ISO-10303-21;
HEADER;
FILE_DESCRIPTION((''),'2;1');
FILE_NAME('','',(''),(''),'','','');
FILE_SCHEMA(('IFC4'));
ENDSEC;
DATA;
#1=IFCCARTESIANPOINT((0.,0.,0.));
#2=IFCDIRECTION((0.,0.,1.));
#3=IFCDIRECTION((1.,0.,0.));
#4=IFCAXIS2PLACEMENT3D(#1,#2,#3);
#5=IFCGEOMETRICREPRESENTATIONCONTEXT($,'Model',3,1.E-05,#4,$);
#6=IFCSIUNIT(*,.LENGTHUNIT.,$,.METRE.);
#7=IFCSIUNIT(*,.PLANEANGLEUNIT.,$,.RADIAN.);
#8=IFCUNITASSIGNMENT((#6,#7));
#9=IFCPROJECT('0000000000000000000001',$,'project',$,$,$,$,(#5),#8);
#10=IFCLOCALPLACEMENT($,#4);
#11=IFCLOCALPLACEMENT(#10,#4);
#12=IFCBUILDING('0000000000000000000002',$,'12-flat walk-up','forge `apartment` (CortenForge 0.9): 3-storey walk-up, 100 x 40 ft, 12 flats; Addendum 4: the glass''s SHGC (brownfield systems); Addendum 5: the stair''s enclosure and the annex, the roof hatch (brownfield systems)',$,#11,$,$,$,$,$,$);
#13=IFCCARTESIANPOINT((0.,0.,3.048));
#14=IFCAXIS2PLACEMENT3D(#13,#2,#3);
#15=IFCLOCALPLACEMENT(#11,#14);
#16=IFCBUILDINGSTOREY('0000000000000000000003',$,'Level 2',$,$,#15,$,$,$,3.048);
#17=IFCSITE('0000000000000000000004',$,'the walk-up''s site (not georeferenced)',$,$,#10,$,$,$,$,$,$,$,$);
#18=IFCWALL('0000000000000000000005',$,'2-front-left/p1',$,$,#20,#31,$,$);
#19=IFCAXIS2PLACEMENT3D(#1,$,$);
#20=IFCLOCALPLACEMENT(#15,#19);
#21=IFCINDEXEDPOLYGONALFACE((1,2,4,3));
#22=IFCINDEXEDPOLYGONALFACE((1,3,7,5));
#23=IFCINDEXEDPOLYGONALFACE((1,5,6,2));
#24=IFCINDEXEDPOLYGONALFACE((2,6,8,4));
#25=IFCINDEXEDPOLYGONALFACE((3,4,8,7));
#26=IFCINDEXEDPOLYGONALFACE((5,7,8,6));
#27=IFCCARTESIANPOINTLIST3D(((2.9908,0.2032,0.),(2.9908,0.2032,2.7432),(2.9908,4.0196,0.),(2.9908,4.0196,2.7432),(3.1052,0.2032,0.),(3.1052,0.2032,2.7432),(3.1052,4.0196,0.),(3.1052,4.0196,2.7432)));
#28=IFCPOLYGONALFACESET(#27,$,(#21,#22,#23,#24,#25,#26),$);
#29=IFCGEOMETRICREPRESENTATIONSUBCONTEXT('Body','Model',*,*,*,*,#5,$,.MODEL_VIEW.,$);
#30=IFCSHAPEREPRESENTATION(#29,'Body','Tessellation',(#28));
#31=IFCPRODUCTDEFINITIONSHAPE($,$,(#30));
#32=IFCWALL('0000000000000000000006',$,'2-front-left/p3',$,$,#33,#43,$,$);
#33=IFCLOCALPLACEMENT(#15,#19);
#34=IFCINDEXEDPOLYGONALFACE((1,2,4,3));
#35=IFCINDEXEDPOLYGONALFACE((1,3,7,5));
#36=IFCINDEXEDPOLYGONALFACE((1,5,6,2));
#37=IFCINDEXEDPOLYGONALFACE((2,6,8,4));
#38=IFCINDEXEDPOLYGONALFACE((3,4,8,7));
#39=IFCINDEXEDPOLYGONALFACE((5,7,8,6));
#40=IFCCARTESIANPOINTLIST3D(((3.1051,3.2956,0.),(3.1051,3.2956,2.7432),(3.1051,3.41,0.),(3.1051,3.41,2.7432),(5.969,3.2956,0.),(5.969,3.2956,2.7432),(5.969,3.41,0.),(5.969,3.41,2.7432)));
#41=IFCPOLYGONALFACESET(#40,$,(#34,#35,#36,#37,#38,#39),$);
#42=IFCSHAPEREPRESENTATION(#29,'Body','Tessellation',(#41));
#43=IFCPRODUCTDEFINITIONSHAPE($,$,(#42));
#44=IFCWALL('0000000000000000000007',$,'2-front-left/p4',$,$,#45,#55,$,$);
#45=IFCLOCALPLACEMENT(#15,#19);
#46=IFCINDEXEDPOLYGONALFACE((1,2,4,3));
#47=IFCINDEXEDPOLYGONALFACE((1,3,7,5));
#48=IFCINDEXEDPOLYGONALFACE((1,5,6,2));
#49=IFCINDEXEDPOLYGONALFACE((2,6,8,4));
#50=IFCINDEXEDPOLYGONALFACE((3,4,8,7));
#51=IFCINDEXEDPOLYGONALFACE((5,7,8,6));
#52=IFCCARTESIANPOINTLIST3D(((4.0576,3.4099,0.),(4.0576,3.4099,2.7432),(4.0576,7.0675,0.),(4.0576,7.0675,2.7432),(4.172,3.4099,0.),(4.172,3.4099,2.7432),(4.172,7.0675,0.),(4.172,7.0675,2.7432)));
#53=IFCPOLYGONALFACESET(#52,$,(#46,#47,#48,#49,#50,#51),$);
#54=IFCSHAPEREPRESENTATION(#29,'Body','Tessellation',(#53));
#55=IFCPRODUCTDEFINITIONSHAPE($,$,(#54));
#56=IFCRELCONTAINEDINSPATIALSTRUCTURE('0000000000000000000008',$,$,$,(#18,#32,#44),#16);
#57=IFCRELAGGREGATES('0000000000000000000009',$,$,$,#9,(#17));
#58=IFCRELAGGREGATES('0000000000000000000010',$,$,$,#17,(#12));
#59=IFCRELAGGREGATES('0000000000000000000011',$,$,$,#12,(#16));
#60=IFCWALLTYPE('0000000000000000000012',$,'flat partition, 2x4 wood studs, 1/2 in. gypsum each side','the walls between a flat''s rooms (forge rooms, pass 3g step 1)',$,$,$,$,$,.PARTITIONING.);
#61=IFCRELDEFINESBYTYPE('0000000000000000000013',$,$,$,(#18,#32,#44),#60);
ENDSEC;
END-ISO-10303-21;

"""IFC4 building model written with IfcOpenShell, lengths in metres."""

from ifc_helpers import new_model, si_unit, frame, frame_2d, origin, origin_with_axes, place, context, subcontext, project, spatial, rectangle, extrude, type_object, element, save


model = new_model("IFC4")

# Units and contexts
model_context = context("Model", 3, precision=1e-05, world=origin_with_axes())
body_context = subcontext(model_context, "Body", "Model", "MODEL_VIEW")
ifc_project = project(units=[si_unit("LENGTHUNIT", "METRE"), si_unit("PLANEANGLEUNIT", "RADIAN")], contexts=[model_context])

# Site, building, storey
site_placement = place(None, origin_with_axes())
site = spatial("IfcSite", under=ifc_project, at=site_placement, Name="the walk-up's site (not georeferenced)")
building_placement = place(site_placement, origin_with_axes())
building = spatial("IfcBuilding", under=site, at=building_placement, Name="12-flat walk-up", Description="forge `apartment` (CortenForge 0.9): 3-storey walk-up, 100 x 40 ft, 12 flats; Addendum 4: the glass's SHGC (brownfield systems); Addendum 5: the stair's enclosure and the annex, the roof hatch (brownfield systems)")
storey_placement = place(building_placement, frame((0.0, 0.0, 3.048), z_axis=(0.0, 0.0, 1.0), x_axis=(1.0, 0.0, 0.0)))
storey = spatial("IfcBuildingStorey", under=building, at=storey_placement, Name="Level 2", Elevation=3.048)

# Walls
wall_type = type_object("IfcWallType", Name="flat partition, 2x4 wood studs, 1/2 in. gypsum each side", Description="the walls between a flat's rooms (forge rooms, pass 3g step 1)", PredefinedType="PARTITIONING")
wall_1_placement = place(storey_placement, frame((2.9909, 0.2032, 0.0), z_axis=(0.0, 0.0, 1.0), x_axis=(1.0, 0.0, 0.0)))
element("IfcWall", 1, at=wall_1_placement, inside=storey, type_object=wall_type, Name="2-front-left/p1", context=body_context, shape_type="SweptSolid", body=[
    extrude(rectangle(XDim=0.1143, YDim=3.8163, at=frame_2d((0.0572, 1.9082))), origin(), (0.0, 0.0, 1.0), 2.7432),
])
wall_2_placement = place(storey_placement, frame((3.1051, 3.2957, 0.0), z_axis=(0.0, 0.0, 1.0), x_axis=(1.0, 0.0, 0.0)))
element("IfcWall", 2, at=wall_2_placement, inside=storey, type_object=wall_type, Name="2-front-left/p3", context=body_context, shape_type="SweptSolid", body=[
    extrude(rectangle(XDim=2.8639, YDim=0.1143, at=frame_2d((1.4319, 0.0571))), origin(), (0.0, 0.0, 1.0), 2.7432),
])
wall_3_placement = place(storey_placement, frame((4.0576, 3.4099, 0.0), z_axis=(0.0, 0.0, 1.0), x_axis=(1.0, 0.0, 0.0)))
element("IfcWall", 3, at=wall_3_placement, inside=storey, type_object=wall_type, Name="2-front-left/p4", context=body_context, shape_type="SweptSolid", body=[
    extrude(rectangle(XDim=0.1143, YDim=3.6576, at=frame_2d((0.0572, 1.8288))), origin(), (0.0, 0.0, 1.0), 2.7432),
])

save(model, "model.ifc")
